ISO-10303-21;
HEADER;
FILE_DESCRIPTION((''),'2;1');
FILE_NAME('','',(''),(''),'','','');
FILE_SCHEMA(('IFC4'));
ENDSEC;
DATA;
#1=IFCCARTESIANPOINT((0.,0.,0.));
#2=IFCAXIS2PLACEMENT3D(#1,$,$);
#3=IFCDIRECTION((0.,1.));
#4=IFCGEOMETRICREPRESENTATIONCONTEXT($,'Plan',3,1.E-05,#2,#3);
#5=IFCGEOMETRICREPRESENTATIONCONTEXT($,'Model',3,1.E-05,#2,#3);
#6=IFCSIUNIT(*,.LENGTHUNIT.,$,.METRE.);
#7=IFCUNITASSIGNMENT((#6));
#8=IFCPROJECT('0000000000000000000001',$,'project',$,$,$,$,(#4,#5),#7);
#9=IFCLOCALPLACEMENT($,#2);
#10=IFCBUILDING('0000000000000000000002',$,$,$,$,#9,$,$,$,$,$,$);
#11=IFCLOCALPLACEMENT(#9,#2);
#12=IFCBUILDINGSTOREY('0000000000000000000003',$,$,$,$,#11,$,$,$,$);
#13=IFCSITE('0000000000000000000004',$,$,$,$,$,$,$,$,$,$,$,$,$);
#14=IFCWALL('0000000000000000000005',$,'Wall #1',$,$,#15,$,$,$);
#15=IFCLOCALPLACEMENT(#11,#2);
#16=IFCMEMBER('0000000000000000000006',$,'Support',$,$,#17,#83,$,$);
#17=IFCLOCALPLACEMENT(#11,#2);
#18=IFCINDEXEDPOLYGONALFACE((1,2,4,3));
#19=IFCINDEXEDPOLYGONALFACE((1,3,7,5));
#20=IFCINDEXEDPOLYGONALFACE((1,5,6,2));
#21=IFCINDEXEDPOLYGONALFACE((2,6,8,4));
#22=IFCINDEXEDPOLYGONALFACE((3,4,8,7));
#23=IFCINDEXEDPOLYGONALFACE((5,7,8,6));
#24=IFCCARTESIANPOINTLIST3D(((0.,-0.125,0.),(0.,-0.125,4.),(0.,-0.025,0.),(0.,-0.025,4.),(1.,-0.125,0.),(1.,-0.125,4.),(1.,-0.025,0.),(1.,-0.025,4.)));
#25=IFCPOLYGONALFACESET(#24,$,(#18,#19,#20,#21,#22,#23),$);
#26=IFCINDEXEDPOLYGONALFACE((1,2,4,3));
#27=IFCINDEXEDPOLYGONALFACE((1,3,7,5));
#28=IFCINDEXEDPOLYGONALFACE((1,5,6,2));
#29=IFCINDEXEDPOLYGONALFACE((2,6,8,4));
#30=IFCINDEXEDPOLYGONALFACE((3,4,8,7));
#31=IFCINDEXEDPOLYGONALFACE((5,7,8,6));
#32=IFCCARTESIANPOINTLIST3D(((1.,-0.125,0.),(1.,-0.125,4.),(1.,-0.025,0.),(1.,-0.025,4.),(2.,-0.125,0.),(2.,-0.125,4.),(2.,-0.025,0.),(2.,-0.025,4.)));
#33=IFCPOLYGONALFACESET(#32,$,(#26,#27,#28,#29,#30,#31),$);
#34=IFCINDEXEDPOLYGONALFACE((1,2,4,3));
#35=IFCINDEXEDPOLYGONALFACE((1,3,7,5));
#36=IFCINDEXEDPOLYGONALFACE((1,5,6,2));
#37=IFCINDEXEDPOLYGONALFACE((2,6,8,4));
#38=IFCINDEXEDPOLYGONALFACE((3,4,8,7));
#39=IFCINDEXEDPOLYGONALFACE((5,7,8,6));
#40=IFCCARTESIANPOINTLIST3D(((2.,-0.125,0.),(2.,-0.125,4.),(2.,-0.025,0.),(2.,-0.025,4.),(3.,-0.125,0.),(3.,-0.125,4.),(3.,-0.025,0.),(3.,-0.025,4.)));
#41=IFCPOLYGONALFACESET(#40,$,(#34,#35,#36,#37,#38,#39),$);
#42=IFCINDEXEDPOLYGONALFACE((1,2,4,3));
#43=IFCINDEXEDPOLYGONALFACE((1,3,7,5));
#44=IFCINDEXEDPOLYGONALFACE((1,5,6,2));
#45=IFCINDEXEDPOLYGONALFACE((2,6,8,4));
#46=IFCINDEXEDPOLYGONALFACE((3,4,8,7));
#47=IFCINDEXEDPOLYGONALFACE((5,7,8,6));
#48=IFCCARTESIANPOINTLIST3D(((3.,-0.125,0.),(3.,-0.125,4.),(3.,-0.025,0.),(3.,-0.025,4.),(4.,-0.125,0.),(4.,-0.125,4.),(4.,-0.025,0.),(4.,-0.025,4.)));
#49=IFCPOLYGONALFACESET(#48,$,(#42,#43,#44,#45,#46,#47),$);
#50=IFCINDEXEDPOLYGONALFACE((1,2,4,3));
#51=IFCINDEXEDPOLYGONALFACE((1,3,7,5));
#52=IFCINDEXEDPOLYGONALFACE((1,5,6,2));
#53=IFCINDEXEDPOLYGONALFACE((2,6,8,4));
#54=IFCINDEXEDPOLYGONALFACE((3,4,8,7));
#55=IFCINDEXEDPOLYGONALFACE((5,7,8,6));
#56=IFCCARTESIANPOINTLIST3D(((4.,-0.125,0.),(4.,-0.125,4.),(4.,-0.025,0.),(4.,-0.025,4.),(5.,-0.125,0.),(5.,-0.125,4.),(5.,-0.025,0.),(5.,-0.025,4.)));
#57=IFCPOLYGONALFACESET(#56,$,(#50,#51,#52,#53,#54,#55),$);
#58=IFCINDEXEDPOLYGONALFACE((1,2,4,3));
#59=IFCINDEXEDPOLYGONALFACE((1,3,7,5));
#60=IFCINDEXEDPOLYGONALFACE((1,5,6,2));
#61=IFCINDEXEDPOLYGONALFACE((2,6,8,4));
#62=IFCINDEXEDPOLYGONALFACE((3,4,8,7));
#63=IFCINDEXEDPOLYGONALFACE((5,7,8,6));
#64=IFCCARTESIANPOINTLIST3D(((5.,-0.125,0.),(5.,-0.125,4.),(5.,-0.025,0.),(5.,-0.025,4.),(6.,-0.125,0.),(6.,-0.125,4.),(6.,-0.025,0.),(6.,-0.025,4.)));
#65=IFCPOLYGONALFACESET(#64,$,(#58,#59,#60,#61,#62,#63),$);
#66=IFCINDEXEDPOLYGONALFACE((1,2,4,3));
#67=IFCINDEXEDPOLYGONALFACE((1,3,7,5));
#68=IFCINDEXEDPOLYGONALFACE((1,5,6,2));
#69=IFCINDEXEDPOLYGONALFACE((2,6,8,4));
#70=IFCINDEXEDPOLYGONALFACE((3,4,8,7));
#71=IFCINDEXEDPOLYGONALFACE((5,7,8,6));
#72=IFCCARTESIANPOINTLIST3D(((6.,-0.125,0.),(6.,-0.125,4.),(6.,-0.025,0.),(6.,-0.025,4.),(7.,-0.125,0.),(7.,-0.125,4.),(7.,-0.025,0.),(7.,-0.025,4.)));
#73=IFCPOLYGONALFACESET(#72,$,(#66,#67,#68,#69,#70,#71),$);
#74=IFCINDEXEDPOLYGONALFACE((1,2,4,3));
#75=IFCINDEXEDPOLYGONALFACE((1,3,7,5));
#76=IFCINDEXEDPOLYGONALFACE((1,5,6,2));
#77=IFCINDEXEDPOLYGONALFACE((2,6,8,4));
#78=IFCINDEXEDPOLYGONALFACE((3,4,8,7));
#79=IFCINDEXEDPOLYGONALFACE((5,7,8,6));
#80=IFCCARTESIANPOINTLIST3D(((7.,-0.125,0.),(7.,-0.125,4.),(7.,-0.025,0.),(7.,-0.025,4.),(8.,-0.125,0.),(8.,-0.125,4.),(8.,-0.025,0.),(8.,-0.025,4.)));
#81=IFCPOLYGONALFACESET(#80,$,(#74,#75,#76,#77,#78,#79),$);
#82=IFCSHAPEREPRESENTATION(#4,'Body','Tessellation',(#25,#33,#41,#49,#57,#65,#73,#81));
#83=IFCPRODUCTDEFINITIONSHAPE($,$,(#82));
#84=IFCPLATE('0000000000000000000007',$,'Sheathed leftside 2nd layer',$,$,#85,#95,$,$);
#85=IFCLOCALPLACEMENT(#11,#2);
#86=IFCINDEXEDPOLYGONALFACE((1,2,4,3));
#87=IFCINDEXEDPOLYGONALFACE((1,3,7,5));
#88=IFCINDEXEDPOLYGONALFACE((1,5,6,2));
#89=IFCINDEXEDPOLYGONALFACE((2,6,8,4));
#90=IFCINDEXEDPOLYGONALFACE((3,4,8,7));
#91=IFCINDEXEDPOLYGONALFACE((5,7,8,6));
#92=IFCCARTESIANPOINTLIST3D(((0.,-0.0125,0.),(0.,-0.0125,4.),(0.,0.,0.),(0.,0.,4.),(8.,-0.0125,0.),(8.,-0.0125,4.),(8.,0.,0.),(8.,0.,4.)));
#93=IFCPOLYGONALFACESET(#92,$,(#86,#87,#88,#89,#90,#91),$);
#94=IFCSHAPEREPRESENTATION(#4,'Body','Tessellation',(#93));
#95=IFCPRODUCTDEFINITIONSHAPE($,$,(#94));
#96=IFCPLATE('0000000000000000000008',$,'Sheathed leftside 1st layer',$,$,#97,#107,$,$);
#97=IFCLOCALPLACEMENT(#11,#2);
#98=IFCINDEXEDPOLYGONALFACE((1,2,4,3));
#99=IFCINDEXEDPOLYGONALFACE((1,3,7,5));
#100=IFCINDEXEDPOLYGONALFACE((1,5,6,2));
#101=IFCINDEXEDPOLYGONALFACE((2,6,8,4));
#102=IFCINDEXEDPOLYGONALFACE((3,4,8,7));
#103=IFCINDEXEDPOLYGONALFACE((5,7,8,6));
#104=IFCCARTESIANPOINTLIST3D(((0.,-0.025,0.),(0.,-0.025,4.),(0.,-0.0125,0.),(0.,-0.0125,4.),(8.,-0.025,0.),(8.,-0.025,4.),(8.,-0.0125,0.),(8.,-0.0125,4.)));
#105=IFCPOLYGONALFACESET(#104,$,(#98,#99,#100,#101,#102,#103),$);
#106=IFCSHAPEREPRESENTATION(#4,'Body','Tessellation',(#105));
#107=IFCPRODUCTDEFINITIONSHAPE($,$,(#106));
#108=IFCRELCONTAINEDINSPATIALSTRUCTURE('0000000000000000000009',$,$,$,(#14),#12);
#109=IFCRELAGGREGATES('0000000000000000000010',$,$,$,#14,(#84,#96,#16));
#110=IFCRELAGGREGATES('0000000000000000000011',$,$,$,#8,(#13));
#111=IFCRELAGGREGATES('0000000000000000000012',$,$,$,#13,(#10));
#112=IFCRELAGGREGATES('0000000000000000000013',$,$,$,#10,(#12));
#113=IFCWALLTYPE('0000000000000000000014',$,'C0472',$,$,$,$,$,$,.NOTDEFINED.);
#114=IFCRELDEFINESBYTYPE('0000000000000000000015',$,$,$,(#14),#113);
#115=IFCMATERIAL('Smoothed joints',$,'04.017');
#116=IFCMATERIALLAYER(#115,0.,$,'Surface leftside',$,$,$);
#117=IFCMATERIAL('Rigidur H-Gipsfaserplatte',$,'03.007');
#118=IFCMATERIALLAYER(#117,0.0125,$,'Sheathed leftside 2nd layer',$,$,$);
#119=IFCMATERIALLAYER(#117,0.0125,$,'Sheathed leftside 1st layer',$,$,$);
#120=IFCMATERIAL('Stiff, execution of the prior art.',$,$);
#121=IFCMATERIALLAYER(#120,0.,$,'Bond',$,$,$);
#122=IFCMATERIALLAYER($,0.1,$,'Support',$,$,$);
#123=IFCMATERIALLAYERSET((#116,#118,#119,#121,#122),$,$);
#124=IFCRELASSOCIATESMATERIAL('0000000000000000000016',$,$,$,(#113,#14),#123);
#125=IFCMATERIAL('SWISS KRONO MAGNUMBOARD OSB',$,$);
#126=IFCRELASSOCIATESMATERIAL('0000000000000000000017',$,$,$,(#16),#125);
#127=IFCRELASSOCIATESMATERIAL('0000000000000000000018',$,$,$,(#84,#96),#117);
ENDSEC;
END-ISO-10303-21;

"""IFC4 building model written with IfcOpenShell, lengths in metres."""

from ifc_helpers import new_model, si_unit, direction, frame, frame_2d, origin, origin_with_axes, place, context, project, spatial, rectangle, extrude, material, layer, layer_set, type_object, element, aggregate, save


model = new_model("IFC4")

# Units and contexts
plan_context = context("Plan", 3, precision=1e-05, world=origin(), true_north=direction((0.0, 1.0)))
model_context = context("Model", 3, precision=1e-05, world=origin(), true_north=direction((0.0, 1.0)))
ifc_project = project(units=[si_unit("LENGTHUNIT", "METRE")], contexts=[plan_context, model_context])

# Site, building, storey
site = spatial("IfcSite", under=ifc_project)
building_placement = place(None, origin())
building = spatial("IfcBuilding", under=site, at=building_placement)
storey_placement = place(building_placement, origin())
storey = spatial("IfcBuildingStorey", under=building, at=storey_placement)

# Wall, member, plates
ifc_material_1 = material(Name="Smoothed joints", Category="04.017")
ifc_layer_1 = layer(ifc_material_1, 0.0, Name="Surface leftside")
ifc_material_2 = material(Name="Rigidur H-Gipsfaserplatte", Category="03.007")
ifc_layer_2 = layer(ifc_material_2, 0.0125, Name="Sheathed leftside 2nd layer")
ifc_layer_3 = layer(ifc_material_2, 0.0125, Name="Sheathed leftside 1st layer")
ifc_material_3 = material(Name="Stiff, execution of the prior art.")
ifc_layer_4 = layer(ifc_material_3, 0.0, Name="Bond")
ifc_layer_5 = layer(None, 0.1, Name="Support")
ifc_layer_set = layer_set([ifc_layer_1, ifc_layer_2, ifc_layer_3, ifc_layer_4, ifc_layer_5])
wall_type = type_object("IfcWallType", Name="C0472", PredefinedType="NOTDEFINED", material=ifc_layer_set)
wall_placement = place(None, frame((0.0, 0.0, 0.0), z_axis=(0.0, -1.0, 0.0), x_axis=(1.0, 0.0, 0.0)))
wall = element("IfcWall", 1, at=wall_placement, inside=storey, type_object=wall_type, material=ifc_layer_set, Name="Wall #1")
ifc_material_4 = material(Name="SWISS KRONO MAGNUMBOARD OSB")
member_placement = place(wall_placement, origin())
member = element("IfcMember", 2, at=member_placement, material=ifc_material_4, Name="Support", context=plan_context, shape_type="SweptSolid", body=[
    extrude(rectangle(XDim=1.0, YDim=0.1, at=frame_2d((0.5, 0.05), x_axis=(1.0, 0.0))), frame((0.0, 4.0, 0.025), z_axis=(0.0, -1.0, 0.0), x_axis=(1.0, 0.0, 0.0)), (0.0, 0.0, 1.0), 4.0),
    extrude(rectangle(XDim=1.0, YDim=0.1, at=frame_2d((0.5, 0.05), x_axis=(1.0, 0.0))), frame((1.0, 4.0, 0.025), z_axis=(0.0, -1.0, 0.0), x_axis=(1.0, 0.0, 0.0)), (0.0, 0.0, 1.0), 4.0),
    extrude(rectangle(XDim=1.0, YDim=0.1, at=frame_2d((0.5, 0.05), x_axis=(1.0, 0.0))), frame((2.0, 4.0, 0.025), z_axis=(0.0, -1.0, 0.0), x_axis=(1.0, 0.0, 0.0)), (0.0, 0.0, 1.0), 4.0),
    extrude(rectangle(XDim=1.0, YDim=0.1, at=frame_2d((0.5, 0.05), x_axis=(1.0, 0.0))), frame((3.0, 4.0, 0.025), z_axis=(0.0, -1.0, 0.0), x_axis=(1.0, 0.0, 0.0)), (0.0, 0.0, 1.0), 4.0),
    extrude(rectangle(XDim=1.0, YDim=0.1, at=frame_2d((0.5, 0.05), x_axis=(1.0, 0.0))), frame((4.0, 4.0, 0.025), z_axis=(0.0, -1.0, 0.0), x_axis=(1.0, 0.0, 0.0)), (0.0, 0.0, 1.0), 4.0),
    extrude(rectangle(XDim=1.0, YDim=0.1, at=frame_2d((0.5, 0.05), x_axis=(1.0, 0.0))), frame((5.0, 4.0, 0.025), z_axis=(0.0, -1.0, 0.0), x_axis=(1.0, 0.0, 0.0)), (0.0, 0.0, 1.0), 4.0),
    extrude(rectangle(XDim=1.0, YDim=0.1, at=frame_2d((0.5, 0.05), x_axis=(1.0, 0.0))), frame((6.0, 4.0, 0.025), z_axis=(0.0, -1.0, 0.0), x_axis=(1.0, 0.0, 0.0)), (0.0, 0.0, 1.0), 4.0),
    extrude(rectangle(XDim=1.0, YDim=0.1, at=frame_2d((0.5, 0.05), x_axis=(1.0, 0.0))), frame((7.0, 4.0, 0.025), z_axis=(0.0, -1.0, 0.0), x_axis=(1.0, 0.0, 0.0)), (0.0, 0.0, 1.0), 4.0),
])
plate_1_placement = place(wall_placement, origin())
plate_1 = element("IfcPlate", 3, at=plate_1_placement, material=ifc_material_2, Name="Sheathed leftside 2nd layer", context=plan_context, shape_type="SweptSolid", body=[
    extrude(rectangle(XDim=8.0, YDim=4.0, at=frame_2d((4.0, 2.0), x_axis=(1.0, 0.0))), origin_with_axes(), (0.0, 0.0, 1.0), 0.0125),
])
plate_2_placement = place(wall_placement, origin())
plate_2 = element("IfcPlate", 4, at=plate_2_placement, material=ifc_material_2, Name="Sheathed leftside 1st layer", context=plan_context, shape_type="SweptSolid", body=[
    extrude(rectangle(XDim=8.0, YDim=4.0, at=frame_2d((4.0, 2.0), x_axis=(1.0, 0.0))), frame((0.0, 0.0, 0.0125), z_axis=(0.0, 0.0, 1.0), x_axis=(1.0, 0.0, 0.0)), (0.0, 0.0, 1.0), 0.0125),
])
aggregate(wall, [plate_1, plate_2, member])

save(model, "model.ifc")
